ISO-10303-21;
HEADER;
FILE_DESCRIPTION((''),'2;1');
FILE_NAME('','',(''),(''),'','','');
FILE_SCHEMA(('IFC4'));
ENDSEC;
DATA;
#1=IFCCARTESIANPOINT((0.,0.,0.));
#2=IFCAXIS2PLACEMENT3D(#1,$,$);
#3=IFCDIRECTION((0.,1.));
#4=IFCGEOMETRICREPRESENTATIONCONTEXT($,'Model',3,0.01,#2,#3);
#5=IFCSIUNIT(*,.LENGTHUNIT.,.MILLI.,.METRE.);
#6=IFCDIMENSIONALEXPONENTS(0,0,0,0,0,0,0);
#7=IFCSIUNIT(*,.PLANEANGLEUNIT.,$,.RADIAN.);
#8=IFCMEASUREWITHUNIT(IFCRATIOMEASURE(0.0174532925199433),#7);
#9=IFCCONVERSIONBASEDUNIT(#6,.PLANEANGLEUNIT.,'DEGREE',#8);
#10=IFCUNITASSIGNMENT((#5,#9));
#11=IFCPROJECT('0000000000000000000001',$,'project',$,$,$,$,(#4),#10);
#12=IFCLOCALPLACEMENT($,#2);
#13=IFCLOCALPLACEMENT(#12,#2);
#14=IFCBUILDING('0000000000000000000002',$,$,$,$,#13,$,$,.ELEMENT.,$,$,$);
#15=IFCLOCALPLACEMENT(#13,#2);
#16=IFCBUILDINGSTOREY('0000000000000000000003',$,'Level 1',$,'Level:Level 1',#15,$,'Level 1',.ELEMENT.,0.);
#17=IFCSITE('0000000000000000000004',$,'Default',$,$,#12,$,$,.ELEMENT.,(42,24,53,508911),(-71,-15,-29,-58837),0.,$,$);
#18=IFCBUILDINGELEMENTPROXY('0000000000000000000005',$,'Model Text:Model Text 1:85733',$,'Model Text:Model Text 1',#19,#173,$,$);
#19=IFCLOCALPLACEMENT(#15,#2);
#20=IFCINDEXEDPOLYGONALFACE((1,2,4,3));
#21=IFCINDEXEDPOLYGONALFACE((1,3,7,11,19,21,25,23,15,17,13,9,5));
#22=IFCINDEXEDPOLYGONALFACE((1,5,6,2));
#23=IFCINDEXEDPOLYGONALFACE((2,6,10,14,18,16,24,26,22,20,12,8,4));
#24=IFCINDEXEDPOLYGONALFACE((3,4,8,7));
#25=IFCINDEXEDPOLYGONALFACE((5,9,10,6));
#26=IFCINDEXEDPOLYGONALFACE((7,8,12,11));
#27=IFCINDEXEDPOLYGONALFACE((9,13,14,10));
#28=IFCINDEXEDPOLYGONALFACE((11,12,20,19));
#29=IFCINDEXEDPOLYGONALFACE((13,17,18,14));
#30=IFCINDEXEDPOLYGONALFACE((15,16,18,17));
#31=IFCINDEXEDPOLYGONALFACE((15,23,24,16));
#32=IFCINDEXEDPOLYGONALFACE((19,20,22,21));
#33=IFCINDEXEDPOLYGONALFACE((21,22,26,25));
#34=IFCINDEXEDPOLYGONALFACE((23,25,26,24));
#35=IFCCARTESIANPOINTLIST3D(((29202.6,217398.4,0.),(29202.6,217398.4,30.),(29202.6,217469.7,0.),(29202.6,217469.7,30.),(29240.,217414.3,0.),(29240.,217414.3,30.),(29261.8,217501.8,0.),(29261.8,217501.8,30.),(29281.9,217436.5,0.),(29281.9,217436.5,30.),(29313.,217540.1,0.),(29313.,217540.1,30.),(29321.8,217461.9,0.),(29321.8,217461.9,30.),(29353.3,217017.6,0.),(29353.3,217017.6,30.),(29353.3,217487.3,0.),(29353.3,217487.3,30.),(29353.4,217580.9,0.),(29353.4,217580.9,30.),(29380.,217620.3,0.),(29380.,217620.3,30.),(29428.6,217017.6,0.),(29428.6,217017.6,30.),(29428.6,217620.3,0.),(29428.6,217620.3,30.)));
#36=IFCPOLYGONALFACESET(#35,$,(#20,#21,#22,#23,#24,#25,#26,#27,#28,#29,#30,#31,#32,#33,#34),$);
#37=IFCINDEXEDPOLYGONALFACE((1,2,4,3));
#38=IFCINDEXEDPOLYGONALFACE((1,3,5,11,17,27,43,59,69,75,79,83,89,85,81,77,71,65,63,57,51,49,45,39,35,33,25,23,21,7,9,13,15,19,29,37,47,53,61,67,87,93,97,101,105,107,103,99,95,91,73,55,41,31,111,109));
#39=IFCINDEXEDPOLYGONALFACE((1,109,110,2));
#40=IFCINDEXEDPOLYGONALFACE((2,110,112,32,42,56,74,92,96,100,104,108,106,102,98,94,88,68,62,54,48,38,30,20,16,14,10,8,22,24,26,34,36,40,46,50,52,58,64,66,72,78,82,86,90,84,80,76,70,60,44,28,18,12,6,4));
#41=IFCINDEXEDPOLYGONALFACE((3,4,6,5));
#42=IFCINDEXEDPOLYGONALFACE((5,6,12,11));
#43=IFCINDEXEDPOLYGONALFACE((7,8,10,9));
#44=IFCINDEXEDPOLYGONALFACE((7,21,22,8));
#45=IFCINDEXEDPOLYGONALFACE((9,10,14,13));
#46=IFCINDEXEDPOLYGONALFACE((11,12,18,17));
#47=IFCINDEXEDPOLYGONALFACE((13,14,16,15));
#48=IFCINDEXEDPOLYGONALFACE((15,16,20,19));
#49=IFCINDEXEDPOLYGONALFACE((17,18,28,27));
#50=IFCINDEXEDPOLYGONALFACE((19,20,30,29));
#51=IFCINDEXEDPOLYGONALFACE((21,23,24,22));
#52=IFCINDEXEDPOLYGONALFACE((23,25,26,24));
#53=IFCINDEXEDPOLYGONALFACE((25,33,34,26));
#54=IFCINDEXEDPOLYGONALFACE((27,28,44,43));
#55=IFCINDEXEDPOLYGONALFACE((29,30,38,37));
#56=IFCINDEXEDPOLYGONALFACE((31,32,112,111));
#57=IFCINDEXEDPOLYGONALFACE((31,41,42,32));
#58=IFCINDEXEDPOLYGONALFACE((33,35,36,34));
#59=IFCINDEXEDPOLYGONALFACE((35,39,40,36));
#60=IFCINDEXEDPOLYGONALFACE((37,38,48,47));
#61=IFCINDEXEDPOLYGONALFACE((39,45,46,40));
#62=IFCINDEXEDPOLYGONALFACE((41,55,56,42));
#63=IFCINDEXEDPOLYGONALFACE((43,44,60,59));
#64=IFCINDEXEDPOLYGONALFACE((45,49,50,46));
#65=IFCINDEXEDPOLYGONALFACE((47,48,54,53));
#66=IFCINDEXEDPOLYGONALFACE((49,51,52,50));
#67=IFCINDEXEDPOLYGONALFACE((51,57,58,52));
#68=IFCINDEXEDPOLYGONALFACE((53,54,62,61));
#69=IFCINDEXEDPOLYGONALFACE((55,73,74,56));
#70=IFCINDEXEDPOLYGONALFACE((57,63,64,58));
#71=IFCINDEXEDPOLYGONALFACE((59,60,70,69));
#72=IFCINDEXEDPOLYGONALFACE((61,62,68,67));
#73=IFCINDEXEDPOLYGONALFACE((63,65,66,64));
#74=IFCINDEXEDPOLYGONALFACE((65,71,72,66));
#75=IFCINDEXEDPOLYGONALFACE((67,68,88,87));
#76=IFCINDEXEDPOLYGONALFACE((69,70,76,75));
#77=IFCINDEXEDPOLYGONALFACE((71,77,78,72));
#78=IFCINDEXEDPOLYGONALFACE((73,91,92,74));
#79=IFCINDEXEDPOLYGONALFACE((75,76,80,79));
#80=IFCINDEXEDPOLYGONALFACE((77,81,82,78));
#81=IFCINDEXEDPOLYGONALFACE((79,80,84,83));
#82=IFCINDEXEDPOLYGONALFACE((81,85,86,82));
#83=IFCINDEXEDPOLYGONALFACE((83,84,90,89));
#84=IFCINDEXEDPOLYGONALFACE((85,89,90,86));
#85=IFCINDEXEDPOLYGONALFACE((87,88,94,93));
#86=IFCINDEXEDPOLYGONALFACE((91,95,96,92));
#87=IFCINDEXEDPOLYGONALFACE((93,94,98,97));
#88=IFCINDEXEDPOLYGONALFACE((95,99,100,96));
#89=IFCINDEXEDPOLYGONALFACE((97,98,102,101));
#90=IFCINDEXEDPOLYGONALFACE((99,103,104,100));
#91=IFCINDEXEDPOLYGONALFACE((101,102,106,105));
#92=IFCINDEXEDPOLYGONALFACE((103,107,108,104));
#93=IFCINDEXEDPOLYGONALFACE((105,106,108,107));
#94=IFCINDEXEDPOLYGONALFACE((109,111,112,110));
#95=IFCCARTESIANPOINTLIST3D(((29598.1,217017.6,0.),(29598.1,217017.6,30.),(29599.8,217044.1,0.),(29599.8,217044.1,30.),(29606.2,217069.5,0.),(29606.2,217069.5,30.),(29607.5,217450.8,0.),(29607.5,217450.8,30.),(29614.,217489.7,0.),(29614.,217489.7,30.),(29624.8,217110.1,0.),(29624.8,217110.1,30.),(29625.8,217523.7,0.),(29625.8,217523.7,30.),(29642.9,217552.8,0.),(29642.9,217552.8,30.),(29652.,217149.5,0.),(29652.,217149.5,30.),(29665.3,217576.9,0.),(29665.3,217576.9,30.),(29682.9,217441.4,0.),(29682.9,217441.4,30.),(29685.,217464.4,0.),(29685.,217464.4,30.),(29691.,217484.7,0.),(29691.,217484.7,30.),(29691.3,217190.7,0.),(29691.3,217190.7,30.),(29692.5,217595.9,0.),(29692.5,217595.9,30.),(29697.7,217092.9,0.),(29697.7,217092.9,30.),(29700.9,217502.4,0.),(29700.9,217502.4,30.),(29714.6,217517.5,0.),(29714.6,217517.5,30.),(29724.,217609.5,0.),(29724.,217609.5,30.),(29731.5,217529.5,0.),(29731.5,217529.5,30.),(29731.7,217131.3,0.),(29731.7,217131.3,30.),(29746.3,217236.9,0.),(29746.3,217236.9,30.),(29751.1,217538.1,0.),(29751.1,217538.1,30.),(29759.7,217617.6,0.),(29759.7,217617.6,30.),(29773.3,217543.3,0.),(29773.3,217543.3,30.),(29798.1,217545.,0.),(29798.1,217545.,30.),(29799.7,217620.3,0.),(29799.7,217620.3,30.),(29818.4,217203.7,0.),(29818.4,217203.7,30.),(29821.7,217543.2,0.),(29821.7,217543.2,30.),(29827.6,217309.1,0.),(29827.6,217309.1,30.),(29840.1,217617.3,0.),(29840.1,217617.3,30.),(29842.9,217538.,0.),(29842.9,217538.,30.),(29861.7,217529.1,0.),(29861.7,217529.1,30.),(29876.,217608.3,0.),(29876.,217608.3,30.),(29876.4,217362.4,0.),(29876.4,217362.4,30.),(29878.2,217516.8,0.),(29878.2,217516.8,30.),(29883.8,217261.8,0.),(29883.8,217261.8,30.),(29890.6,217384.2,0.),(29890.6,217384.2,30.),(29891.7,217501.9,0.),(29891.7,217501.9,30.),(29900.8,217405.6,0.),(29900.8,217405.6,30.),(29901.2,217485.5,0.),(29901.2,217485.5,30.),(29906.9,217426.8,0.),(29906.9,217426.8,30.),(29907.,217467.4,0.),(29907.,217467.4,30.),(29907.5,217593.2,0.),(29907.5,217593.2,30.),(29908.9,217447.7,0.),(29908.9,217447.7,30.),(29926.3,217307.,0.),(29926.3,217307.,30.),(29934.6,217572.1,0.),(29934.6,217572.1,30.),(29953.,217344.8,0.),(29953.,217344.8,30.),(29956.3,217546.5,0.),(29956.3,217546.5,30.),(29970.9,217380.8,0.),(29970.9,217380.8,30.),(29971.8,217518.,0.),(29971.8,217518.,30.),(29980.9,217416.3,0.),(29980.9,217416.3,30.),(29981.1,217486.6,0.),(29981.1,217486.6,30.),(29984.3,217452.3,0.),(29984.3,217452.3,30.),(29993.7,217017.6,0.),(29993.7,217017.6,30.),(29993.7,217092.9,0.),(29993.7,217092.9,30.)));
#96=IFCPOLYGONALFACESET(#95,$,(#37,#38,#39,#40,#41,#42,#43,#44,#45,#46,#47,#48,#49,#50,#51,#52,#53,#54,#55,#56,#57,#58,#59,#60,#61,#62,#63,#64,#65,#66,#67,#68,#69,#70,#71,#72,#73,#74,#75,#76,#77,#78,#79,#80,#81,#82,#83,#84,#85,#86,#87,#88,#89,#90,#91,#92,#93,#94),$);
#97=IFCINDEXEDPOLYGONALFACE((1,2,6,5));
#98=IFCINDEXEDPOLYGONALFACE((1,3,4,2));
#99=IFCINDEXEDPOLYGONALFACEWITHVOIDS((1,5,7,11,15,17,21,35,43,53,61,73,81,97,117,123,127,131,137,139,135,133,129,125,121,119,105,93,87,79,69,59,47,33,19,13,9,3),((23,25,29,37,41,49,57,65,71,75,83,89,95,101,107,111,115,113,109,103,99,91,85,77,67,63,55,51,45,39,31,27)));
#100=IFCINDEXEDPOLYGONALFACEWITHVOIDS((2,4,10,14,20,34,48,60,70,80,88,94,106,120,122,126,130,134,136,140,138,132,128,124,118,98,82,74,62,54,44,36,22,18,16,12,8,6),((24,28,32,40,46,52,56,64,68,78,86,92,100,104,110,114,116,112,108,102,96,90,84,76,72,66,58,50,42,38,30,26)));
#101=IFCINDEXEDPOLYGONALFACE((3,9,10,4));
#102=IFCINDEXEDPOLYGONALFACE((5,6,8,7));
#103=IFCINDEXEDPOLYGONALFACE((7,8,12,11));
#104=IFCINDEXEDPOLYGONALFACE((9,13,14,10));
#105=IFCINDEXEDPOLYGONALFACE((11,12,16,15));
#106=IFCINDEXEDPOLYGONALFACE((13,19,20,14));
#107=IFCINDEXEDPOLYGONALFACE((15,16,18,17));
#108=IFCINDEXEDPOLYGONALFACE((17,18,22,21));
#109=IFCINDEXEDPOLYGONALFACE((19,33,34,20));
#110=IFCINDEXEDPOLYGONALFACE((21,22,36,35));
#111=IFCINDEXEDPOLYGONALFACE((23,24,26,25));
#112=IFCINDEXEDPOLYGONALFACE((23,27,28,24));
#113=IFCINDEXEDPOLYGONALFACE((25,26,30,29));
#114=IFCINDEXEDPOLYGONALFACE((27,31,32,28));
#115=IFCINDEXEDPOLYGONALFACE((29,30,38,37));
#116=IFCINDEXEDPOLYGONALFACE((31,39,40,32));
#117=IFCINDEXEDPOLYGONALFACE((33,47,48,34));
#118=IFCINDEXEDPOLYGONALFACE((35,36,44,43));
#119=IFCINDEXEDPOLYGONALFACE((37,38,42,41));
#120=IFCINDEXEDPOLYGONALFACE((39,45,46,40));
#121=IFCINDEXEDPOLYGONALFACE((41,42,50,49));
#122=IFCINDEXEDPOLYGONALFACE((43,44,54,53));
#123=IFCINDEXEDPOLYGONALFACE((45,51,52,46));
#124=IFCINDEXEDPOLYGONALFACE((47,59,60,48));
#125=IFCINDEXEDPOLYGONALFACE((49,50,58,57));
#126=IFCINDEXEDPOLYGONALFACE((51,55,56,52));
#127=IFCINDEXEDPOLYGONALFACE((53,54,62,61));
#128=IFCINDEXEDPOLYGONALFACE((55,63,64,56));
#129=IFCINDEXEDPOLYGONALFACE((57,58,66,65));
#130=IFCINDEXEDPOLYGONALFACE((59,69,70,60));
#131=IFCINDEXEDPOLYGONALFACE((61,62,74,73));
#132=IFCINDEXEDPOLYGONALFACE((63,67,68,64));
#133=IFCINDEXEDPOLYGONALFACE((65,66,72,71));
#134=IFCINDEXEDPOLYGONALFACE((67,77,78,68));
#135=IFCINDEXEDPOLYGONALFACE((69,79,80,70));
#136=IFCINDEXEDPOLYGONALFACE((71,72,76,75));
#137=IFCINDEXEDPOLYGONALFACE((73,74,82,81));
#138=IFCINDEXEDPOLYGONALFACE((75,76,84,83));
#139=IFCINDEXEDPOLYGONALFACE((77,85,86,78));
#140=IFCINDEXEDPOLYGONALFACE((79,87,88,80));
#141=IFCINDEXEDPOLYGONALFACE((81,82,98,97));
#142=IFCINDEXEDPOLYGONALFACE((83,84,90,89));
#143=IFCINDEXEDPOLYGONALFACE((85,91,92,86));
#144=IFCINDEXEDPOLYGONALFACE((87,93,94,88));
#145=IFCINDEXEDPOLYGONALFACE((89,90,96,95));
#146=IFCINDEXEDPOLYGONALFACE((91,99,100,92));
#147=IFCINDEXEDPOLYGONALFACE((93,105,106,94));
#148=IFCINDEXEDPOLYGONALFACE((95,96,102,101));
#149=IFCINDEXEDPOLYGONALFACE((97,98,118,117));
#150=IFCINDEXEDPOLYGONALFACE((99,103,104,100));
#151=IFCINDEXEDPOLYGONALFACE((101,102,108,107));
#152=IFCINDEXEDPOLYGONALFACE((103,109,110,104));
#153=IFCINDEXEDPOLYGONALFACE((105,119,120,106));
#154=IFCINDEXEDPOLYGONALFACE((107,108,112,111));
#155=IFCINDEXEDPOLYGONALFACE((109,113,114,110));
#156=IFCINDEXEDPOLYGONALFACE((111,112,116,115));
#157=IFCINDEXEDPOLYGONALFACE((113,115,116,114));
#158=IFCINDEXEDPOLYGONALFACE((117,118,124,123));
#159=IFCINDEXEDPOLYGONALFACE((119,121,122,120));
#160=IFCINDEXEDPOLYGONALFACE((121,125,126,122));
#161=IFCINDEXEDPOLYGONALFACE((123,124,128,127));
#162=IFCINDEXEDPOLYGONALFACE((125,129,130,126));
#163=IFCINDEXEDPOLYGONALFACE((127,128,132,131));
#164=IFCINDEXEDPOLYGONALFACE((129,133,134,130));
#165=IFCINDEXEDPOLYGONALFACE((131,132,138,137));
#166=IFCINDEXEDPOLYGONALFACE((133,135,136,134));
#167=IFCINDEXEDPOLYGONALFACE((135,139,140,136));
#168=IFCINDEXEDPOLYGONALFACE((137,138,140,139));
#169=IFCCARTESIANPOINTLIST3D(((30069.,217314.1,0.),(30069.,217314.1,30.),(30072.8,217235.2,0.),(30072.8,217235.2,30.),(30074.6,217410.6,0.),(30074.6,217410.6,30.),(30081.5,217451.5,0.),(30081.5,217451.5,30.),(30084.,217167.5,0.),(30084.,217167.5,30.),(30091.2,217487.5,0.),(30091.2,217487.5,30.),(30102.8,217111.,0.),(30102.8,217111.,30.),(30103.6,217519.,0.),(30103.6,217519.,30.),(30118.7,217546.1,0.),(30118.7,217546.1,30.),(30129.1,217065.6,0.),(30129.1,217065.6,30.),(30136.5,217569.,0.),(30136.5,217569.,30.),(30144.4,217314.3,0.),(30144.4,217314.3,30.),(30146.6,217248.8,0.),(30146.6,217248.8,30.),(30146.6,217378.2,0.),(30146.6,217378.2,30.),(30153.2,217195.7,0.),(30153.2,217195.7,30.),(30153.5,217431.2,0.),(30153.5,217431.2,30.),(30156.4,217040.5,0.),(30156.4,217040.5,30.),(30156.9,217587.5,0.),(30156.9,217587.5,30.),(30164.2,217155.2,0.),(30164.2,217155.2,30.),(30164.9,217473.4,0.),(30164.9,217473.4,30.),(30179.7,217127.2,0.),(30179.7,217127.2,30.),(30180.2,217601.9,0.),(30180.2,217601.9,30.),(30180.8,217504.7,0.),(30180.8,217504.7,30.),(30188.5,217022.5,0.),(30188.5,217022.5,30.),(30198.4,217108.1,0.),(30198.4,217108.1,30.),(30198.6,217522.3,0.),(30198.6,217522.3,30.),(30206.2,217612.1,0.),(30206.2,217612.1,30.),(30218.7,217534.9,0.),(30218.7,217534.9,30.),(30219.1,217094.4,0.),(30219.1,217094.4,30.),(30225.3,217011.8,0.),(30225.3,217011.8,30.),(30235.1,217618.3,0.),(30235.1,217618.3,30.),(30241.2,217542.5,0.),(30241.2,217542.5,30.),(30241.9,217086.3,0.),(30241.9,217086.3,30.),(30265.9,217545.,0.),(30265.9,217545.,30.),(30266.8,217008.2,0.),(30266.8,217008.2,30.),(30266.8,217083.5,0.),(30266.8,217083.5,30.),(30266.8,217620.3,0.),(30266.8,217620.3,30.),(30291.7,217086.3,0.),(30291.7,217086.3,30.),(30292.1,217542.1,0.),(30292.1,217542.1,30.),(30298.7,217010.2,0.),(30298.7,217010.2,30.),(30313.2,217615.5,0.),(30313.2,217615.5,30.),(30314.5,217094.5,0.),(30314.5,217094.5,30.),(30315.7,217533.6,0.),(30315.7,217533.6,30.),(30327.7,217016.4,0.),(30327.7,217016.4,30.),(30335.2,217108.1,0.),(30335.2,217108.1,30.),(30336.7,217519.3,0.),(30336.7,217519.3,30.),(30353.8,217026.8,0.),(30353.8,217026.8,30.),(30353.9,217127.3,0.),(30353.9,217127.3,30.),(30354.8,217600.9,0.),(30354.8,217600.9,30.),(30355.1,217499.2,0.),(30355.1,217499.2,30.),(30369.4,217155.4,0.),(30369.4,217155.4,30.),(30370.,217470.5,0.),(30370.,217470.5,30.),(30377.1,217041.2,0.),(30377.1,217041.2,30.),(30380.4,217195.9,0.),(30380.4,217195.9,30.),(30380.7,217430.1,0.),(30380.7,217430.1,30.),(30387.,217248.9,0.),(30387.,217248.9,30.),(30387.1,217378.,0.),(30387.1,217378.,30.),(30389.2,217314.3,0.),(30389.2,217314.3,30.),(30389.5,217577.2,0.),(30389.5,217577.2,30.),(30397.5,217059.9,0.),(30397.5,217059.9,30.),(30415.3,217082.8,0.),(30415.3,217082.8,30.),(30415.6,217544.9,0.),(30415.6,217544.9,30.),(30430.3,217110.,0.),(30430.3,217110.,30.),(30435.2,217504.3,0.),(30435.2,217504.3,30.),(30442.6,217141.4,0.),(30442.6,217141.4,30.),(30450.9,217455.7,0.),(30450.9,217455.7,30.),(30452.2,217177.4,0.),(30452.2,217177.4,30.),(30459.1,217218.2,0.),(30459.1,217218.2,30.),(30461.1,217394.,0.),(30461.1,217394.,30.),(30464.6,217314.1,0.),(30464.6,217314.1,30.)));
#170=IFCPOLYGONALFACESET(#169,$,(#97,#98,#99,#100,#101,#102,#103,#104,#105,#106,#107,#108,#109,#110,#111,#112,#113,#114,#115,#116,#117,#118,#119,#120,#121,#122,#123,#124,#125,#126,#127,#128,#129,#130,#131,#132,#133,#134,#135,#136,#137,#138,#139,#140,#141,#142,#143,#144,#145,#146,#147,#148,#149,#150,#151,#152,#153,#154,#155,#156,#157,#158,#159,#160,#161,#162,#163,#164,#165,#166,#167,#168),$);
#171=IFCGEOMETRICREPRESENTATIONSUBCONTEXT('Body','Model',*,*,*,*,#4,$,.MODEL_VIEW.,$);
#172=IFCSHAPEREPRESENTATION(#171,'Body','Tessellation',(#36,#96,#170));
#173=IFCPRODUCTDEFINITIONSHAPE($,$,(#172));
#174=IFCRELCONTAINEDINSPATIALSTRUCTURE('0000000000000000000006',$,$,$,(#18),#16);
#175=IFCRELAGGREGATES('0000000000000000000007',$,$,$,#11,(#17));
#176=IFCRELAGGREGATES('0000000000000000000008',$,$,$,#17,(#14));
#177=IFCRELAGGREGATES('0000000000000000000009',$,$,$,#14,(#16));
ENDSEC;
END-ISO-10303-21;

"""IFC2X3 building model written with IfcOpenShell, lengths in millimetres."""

from ifc_helpers import new_model, entity, si_unit, converted_unit, direction, frame, origin, place, context, subcontext, project, spatial, polyline, outline, extrude, element, save


model = new_model("IFC2X3")

# Units and contexts
model_context = context("Model", 3, precision=0.01, world=origin(), true_north=direction((0.0, 1.0)))
body_context = subcontext(model_context, "Body", "Model", "MODEL_VIEW")
ifc_project = project(units=[si_unit("LENGTHUNIT", "METRE", prefix="MILLI"), converted_unit("PLANEANGLEUNIT", "DEGREE", entity("IfcRatioMeasure", 0.0174532925199433), si_unit("PLANEANGLEUNIT", "RADIAN"), dimensions=[0, 0, 0, 0, 0, 0, 0])], contexts=[model_context])

# Site, building, storey
site_placement = place(None, origin())
site = spatial("IfcSite", under=ifc_project, at=site_placement, Name="Default", CompositionType="ELEMENT", RefLatitude=(42, 24, 53, 508911), RefLongitude=(-71, -15, -29, -58837), RefElevation=0.0)
building_placement = place(site_placement, origin())
building = spatial("IfcBuilding", under=site, at=building_placement, CompositionType="ELEMENT")
storey_placement = place(building_placement, origin())
storey = spatial("IfcBuildingStorey", under=building, at=storey_placement, Name="Level 1", ObjectType="Level:Level 1", LongName="Level 1", CompositionType="ELEMENT", Elevation=0.0)

# Building element proxy
proxy_1_placement = place(storey_placement, origin())
element("IfcBuildingElementProxy", 1, at=proxy_1_placement, inside=storey, Name="Model Text:Model Text 1:85733", ObjectType="Model Text:Model Text 1", context=body_context, shape_type="SweptSolid", body=[
    extrude(outline(polyline([(-410.6, -111.6), (192.1, -111.6), (192.1, -63.1), (152.7, -36.4), (111.9, 4.0), (73.6, 55.2), (41.4, 114.4), (-29.8, 114.4), (-13.9, 77.0), (8.3, 35.1), (33.7, -4.8), (59.1, -36.3), (-410.6, -36.3), (-410.6, -111.6)])), frame((29317.0, 217428.2, 0.0), z_axis=(0.0, 0.0, 1.0), x_axis=(0.0, 1.0, 0.0)), (0.0, 0.0, 1.0), 30.0),
    extrude(outline(polyline([(-190.2, -317.5), (-190.2, -392.8), (205.4, -392.8), (203.7, -366.3), (197.3, -340.9), (178.7, -300.3), (151.5, -260.9), (112.2, -219.7), (57.2, -173.6), (-24.1, -101.3), (-72.9, -48.0), (-87.1, -26.3), (-97.3, -4.8), (-103.4, 16.4), (-105.4, 37.3), (-103.5, 57.0), (-97.7, 75.0), (-88.2, 91.5), (-74.7, 106.4), (-58.2, 118.7), (-39.4, 127.5), (-18.2, 132.8), (5.4, 134.6), (30.2, 132.9), (52.4, 127.7), (72.0, 119.1), (88.9, 107.1), (102.6, 92.0), (112.5, 74.3), (118.5, 54.0), (120.6, 31.0), (196.0, 40.4), (189.5, 79.3), (177.7, 113.3), (160.6, 142.4), (138.2, 166.5), (111.0, 185.5), (79.5, 199.1), (43.8, 207.2), (3.8, 209.9), (-36.6, 206.9), (-72.5, 197.9), (-104.0, 182.8), (-131.1, 161.7), (-152.8, 136.1), (-168.3, 107.6), (-177.6, 76.2), (-180.8, 41.9), (-177.4, 5.8), (-167.4, -29.6), (-149.5, -65.6), (-122.8, -103.4), (-80.3, -148.6), (-14.9, -206.7), (71.8, -279.1), (105.8, -317.5), (-190.2, -317.5)])), frame((29803.5, 217410.4, 0.0), z_axis=(0.0, 0.0, -1.0), x_axis=(-1.0, 0.0, 0.0)), (0.0, 0.0, -1.0), 30.0),
    extrude(outline(polyline([(-10.6, -198.7), (68.3, -198.7), (136.5, -190.7), (193.9, -174.7), (240.5, -150.6), (266.9, -124.4), (286.3, -93.2), (298.8, -57.0), (304.3, -15.7), (303.8, 16.2), (299.0, 45.5), (289.9, 72.1), (276.6, 96.0), (258.9, 117.3), (236.9, 136.2), (210.4, 152.5), (179.6, 166.3), (144.1, 177.6), (103.7, 186.3), (8.2, 196.4), (-71.8, 196.7), (-134.0, 189.4), (-183.3, 176.1), (-224.7, 158.4), (-258.2, 133.9), (-283.5, 100.3), (-300.1, 59.5), (-307.1, 13.4), (-306.6, -18.4), (-301.8, -47.5), (-292.8, -74.0), (-279.6, -97.9), (-262.0, -119.2), (-240.0, -138.1), (-213.6, -154.5), (-182.8, -168.4), (-147.3, -179.8), (-106.7, -188.6), (-10.6, -198.7)]), holes=[polyline([(-7.2, -123.5), (-71.0, -118.2), (-123.6, -108.8), (-165.2, -95.4), (-195.7, -78.0), (-212.4, -59.4), (-224.1, -38.7), (-230.6, -15.9), (-231.9, 8.9), (-227.8, 35.0), (-218.1, 58.1), (-202.8, 78.4), (-182.0, 95.8), (-152.6, 109.4), (-111.7, 118.1), (-59.4, 122.0), (4.4, 121.1), (69.6, 115.8), (122.2, 106.7), (162.2, 93.7), (189.5, 77.0), (207.7, 57.4), (220.4, 36.0), (227.5, 12.8), (229.1, -12.1), (225.2, -36.8), (215.9, -59.2), (201.3, -79.3), (181.4, -97.1), (152.6, -111.2), (111.6, -120.3), (58.3, -124.4), (-7.2, -123.5)])]), frame((30268.0, 217312.9, 0.0), z_axis=(0.0, 0.0, 1.0), x_axis=(0.047515, -0.998871, 0.0)), (0.0, 0.0, 1.0), 30.0),
])

save(model, "model.ifc")
